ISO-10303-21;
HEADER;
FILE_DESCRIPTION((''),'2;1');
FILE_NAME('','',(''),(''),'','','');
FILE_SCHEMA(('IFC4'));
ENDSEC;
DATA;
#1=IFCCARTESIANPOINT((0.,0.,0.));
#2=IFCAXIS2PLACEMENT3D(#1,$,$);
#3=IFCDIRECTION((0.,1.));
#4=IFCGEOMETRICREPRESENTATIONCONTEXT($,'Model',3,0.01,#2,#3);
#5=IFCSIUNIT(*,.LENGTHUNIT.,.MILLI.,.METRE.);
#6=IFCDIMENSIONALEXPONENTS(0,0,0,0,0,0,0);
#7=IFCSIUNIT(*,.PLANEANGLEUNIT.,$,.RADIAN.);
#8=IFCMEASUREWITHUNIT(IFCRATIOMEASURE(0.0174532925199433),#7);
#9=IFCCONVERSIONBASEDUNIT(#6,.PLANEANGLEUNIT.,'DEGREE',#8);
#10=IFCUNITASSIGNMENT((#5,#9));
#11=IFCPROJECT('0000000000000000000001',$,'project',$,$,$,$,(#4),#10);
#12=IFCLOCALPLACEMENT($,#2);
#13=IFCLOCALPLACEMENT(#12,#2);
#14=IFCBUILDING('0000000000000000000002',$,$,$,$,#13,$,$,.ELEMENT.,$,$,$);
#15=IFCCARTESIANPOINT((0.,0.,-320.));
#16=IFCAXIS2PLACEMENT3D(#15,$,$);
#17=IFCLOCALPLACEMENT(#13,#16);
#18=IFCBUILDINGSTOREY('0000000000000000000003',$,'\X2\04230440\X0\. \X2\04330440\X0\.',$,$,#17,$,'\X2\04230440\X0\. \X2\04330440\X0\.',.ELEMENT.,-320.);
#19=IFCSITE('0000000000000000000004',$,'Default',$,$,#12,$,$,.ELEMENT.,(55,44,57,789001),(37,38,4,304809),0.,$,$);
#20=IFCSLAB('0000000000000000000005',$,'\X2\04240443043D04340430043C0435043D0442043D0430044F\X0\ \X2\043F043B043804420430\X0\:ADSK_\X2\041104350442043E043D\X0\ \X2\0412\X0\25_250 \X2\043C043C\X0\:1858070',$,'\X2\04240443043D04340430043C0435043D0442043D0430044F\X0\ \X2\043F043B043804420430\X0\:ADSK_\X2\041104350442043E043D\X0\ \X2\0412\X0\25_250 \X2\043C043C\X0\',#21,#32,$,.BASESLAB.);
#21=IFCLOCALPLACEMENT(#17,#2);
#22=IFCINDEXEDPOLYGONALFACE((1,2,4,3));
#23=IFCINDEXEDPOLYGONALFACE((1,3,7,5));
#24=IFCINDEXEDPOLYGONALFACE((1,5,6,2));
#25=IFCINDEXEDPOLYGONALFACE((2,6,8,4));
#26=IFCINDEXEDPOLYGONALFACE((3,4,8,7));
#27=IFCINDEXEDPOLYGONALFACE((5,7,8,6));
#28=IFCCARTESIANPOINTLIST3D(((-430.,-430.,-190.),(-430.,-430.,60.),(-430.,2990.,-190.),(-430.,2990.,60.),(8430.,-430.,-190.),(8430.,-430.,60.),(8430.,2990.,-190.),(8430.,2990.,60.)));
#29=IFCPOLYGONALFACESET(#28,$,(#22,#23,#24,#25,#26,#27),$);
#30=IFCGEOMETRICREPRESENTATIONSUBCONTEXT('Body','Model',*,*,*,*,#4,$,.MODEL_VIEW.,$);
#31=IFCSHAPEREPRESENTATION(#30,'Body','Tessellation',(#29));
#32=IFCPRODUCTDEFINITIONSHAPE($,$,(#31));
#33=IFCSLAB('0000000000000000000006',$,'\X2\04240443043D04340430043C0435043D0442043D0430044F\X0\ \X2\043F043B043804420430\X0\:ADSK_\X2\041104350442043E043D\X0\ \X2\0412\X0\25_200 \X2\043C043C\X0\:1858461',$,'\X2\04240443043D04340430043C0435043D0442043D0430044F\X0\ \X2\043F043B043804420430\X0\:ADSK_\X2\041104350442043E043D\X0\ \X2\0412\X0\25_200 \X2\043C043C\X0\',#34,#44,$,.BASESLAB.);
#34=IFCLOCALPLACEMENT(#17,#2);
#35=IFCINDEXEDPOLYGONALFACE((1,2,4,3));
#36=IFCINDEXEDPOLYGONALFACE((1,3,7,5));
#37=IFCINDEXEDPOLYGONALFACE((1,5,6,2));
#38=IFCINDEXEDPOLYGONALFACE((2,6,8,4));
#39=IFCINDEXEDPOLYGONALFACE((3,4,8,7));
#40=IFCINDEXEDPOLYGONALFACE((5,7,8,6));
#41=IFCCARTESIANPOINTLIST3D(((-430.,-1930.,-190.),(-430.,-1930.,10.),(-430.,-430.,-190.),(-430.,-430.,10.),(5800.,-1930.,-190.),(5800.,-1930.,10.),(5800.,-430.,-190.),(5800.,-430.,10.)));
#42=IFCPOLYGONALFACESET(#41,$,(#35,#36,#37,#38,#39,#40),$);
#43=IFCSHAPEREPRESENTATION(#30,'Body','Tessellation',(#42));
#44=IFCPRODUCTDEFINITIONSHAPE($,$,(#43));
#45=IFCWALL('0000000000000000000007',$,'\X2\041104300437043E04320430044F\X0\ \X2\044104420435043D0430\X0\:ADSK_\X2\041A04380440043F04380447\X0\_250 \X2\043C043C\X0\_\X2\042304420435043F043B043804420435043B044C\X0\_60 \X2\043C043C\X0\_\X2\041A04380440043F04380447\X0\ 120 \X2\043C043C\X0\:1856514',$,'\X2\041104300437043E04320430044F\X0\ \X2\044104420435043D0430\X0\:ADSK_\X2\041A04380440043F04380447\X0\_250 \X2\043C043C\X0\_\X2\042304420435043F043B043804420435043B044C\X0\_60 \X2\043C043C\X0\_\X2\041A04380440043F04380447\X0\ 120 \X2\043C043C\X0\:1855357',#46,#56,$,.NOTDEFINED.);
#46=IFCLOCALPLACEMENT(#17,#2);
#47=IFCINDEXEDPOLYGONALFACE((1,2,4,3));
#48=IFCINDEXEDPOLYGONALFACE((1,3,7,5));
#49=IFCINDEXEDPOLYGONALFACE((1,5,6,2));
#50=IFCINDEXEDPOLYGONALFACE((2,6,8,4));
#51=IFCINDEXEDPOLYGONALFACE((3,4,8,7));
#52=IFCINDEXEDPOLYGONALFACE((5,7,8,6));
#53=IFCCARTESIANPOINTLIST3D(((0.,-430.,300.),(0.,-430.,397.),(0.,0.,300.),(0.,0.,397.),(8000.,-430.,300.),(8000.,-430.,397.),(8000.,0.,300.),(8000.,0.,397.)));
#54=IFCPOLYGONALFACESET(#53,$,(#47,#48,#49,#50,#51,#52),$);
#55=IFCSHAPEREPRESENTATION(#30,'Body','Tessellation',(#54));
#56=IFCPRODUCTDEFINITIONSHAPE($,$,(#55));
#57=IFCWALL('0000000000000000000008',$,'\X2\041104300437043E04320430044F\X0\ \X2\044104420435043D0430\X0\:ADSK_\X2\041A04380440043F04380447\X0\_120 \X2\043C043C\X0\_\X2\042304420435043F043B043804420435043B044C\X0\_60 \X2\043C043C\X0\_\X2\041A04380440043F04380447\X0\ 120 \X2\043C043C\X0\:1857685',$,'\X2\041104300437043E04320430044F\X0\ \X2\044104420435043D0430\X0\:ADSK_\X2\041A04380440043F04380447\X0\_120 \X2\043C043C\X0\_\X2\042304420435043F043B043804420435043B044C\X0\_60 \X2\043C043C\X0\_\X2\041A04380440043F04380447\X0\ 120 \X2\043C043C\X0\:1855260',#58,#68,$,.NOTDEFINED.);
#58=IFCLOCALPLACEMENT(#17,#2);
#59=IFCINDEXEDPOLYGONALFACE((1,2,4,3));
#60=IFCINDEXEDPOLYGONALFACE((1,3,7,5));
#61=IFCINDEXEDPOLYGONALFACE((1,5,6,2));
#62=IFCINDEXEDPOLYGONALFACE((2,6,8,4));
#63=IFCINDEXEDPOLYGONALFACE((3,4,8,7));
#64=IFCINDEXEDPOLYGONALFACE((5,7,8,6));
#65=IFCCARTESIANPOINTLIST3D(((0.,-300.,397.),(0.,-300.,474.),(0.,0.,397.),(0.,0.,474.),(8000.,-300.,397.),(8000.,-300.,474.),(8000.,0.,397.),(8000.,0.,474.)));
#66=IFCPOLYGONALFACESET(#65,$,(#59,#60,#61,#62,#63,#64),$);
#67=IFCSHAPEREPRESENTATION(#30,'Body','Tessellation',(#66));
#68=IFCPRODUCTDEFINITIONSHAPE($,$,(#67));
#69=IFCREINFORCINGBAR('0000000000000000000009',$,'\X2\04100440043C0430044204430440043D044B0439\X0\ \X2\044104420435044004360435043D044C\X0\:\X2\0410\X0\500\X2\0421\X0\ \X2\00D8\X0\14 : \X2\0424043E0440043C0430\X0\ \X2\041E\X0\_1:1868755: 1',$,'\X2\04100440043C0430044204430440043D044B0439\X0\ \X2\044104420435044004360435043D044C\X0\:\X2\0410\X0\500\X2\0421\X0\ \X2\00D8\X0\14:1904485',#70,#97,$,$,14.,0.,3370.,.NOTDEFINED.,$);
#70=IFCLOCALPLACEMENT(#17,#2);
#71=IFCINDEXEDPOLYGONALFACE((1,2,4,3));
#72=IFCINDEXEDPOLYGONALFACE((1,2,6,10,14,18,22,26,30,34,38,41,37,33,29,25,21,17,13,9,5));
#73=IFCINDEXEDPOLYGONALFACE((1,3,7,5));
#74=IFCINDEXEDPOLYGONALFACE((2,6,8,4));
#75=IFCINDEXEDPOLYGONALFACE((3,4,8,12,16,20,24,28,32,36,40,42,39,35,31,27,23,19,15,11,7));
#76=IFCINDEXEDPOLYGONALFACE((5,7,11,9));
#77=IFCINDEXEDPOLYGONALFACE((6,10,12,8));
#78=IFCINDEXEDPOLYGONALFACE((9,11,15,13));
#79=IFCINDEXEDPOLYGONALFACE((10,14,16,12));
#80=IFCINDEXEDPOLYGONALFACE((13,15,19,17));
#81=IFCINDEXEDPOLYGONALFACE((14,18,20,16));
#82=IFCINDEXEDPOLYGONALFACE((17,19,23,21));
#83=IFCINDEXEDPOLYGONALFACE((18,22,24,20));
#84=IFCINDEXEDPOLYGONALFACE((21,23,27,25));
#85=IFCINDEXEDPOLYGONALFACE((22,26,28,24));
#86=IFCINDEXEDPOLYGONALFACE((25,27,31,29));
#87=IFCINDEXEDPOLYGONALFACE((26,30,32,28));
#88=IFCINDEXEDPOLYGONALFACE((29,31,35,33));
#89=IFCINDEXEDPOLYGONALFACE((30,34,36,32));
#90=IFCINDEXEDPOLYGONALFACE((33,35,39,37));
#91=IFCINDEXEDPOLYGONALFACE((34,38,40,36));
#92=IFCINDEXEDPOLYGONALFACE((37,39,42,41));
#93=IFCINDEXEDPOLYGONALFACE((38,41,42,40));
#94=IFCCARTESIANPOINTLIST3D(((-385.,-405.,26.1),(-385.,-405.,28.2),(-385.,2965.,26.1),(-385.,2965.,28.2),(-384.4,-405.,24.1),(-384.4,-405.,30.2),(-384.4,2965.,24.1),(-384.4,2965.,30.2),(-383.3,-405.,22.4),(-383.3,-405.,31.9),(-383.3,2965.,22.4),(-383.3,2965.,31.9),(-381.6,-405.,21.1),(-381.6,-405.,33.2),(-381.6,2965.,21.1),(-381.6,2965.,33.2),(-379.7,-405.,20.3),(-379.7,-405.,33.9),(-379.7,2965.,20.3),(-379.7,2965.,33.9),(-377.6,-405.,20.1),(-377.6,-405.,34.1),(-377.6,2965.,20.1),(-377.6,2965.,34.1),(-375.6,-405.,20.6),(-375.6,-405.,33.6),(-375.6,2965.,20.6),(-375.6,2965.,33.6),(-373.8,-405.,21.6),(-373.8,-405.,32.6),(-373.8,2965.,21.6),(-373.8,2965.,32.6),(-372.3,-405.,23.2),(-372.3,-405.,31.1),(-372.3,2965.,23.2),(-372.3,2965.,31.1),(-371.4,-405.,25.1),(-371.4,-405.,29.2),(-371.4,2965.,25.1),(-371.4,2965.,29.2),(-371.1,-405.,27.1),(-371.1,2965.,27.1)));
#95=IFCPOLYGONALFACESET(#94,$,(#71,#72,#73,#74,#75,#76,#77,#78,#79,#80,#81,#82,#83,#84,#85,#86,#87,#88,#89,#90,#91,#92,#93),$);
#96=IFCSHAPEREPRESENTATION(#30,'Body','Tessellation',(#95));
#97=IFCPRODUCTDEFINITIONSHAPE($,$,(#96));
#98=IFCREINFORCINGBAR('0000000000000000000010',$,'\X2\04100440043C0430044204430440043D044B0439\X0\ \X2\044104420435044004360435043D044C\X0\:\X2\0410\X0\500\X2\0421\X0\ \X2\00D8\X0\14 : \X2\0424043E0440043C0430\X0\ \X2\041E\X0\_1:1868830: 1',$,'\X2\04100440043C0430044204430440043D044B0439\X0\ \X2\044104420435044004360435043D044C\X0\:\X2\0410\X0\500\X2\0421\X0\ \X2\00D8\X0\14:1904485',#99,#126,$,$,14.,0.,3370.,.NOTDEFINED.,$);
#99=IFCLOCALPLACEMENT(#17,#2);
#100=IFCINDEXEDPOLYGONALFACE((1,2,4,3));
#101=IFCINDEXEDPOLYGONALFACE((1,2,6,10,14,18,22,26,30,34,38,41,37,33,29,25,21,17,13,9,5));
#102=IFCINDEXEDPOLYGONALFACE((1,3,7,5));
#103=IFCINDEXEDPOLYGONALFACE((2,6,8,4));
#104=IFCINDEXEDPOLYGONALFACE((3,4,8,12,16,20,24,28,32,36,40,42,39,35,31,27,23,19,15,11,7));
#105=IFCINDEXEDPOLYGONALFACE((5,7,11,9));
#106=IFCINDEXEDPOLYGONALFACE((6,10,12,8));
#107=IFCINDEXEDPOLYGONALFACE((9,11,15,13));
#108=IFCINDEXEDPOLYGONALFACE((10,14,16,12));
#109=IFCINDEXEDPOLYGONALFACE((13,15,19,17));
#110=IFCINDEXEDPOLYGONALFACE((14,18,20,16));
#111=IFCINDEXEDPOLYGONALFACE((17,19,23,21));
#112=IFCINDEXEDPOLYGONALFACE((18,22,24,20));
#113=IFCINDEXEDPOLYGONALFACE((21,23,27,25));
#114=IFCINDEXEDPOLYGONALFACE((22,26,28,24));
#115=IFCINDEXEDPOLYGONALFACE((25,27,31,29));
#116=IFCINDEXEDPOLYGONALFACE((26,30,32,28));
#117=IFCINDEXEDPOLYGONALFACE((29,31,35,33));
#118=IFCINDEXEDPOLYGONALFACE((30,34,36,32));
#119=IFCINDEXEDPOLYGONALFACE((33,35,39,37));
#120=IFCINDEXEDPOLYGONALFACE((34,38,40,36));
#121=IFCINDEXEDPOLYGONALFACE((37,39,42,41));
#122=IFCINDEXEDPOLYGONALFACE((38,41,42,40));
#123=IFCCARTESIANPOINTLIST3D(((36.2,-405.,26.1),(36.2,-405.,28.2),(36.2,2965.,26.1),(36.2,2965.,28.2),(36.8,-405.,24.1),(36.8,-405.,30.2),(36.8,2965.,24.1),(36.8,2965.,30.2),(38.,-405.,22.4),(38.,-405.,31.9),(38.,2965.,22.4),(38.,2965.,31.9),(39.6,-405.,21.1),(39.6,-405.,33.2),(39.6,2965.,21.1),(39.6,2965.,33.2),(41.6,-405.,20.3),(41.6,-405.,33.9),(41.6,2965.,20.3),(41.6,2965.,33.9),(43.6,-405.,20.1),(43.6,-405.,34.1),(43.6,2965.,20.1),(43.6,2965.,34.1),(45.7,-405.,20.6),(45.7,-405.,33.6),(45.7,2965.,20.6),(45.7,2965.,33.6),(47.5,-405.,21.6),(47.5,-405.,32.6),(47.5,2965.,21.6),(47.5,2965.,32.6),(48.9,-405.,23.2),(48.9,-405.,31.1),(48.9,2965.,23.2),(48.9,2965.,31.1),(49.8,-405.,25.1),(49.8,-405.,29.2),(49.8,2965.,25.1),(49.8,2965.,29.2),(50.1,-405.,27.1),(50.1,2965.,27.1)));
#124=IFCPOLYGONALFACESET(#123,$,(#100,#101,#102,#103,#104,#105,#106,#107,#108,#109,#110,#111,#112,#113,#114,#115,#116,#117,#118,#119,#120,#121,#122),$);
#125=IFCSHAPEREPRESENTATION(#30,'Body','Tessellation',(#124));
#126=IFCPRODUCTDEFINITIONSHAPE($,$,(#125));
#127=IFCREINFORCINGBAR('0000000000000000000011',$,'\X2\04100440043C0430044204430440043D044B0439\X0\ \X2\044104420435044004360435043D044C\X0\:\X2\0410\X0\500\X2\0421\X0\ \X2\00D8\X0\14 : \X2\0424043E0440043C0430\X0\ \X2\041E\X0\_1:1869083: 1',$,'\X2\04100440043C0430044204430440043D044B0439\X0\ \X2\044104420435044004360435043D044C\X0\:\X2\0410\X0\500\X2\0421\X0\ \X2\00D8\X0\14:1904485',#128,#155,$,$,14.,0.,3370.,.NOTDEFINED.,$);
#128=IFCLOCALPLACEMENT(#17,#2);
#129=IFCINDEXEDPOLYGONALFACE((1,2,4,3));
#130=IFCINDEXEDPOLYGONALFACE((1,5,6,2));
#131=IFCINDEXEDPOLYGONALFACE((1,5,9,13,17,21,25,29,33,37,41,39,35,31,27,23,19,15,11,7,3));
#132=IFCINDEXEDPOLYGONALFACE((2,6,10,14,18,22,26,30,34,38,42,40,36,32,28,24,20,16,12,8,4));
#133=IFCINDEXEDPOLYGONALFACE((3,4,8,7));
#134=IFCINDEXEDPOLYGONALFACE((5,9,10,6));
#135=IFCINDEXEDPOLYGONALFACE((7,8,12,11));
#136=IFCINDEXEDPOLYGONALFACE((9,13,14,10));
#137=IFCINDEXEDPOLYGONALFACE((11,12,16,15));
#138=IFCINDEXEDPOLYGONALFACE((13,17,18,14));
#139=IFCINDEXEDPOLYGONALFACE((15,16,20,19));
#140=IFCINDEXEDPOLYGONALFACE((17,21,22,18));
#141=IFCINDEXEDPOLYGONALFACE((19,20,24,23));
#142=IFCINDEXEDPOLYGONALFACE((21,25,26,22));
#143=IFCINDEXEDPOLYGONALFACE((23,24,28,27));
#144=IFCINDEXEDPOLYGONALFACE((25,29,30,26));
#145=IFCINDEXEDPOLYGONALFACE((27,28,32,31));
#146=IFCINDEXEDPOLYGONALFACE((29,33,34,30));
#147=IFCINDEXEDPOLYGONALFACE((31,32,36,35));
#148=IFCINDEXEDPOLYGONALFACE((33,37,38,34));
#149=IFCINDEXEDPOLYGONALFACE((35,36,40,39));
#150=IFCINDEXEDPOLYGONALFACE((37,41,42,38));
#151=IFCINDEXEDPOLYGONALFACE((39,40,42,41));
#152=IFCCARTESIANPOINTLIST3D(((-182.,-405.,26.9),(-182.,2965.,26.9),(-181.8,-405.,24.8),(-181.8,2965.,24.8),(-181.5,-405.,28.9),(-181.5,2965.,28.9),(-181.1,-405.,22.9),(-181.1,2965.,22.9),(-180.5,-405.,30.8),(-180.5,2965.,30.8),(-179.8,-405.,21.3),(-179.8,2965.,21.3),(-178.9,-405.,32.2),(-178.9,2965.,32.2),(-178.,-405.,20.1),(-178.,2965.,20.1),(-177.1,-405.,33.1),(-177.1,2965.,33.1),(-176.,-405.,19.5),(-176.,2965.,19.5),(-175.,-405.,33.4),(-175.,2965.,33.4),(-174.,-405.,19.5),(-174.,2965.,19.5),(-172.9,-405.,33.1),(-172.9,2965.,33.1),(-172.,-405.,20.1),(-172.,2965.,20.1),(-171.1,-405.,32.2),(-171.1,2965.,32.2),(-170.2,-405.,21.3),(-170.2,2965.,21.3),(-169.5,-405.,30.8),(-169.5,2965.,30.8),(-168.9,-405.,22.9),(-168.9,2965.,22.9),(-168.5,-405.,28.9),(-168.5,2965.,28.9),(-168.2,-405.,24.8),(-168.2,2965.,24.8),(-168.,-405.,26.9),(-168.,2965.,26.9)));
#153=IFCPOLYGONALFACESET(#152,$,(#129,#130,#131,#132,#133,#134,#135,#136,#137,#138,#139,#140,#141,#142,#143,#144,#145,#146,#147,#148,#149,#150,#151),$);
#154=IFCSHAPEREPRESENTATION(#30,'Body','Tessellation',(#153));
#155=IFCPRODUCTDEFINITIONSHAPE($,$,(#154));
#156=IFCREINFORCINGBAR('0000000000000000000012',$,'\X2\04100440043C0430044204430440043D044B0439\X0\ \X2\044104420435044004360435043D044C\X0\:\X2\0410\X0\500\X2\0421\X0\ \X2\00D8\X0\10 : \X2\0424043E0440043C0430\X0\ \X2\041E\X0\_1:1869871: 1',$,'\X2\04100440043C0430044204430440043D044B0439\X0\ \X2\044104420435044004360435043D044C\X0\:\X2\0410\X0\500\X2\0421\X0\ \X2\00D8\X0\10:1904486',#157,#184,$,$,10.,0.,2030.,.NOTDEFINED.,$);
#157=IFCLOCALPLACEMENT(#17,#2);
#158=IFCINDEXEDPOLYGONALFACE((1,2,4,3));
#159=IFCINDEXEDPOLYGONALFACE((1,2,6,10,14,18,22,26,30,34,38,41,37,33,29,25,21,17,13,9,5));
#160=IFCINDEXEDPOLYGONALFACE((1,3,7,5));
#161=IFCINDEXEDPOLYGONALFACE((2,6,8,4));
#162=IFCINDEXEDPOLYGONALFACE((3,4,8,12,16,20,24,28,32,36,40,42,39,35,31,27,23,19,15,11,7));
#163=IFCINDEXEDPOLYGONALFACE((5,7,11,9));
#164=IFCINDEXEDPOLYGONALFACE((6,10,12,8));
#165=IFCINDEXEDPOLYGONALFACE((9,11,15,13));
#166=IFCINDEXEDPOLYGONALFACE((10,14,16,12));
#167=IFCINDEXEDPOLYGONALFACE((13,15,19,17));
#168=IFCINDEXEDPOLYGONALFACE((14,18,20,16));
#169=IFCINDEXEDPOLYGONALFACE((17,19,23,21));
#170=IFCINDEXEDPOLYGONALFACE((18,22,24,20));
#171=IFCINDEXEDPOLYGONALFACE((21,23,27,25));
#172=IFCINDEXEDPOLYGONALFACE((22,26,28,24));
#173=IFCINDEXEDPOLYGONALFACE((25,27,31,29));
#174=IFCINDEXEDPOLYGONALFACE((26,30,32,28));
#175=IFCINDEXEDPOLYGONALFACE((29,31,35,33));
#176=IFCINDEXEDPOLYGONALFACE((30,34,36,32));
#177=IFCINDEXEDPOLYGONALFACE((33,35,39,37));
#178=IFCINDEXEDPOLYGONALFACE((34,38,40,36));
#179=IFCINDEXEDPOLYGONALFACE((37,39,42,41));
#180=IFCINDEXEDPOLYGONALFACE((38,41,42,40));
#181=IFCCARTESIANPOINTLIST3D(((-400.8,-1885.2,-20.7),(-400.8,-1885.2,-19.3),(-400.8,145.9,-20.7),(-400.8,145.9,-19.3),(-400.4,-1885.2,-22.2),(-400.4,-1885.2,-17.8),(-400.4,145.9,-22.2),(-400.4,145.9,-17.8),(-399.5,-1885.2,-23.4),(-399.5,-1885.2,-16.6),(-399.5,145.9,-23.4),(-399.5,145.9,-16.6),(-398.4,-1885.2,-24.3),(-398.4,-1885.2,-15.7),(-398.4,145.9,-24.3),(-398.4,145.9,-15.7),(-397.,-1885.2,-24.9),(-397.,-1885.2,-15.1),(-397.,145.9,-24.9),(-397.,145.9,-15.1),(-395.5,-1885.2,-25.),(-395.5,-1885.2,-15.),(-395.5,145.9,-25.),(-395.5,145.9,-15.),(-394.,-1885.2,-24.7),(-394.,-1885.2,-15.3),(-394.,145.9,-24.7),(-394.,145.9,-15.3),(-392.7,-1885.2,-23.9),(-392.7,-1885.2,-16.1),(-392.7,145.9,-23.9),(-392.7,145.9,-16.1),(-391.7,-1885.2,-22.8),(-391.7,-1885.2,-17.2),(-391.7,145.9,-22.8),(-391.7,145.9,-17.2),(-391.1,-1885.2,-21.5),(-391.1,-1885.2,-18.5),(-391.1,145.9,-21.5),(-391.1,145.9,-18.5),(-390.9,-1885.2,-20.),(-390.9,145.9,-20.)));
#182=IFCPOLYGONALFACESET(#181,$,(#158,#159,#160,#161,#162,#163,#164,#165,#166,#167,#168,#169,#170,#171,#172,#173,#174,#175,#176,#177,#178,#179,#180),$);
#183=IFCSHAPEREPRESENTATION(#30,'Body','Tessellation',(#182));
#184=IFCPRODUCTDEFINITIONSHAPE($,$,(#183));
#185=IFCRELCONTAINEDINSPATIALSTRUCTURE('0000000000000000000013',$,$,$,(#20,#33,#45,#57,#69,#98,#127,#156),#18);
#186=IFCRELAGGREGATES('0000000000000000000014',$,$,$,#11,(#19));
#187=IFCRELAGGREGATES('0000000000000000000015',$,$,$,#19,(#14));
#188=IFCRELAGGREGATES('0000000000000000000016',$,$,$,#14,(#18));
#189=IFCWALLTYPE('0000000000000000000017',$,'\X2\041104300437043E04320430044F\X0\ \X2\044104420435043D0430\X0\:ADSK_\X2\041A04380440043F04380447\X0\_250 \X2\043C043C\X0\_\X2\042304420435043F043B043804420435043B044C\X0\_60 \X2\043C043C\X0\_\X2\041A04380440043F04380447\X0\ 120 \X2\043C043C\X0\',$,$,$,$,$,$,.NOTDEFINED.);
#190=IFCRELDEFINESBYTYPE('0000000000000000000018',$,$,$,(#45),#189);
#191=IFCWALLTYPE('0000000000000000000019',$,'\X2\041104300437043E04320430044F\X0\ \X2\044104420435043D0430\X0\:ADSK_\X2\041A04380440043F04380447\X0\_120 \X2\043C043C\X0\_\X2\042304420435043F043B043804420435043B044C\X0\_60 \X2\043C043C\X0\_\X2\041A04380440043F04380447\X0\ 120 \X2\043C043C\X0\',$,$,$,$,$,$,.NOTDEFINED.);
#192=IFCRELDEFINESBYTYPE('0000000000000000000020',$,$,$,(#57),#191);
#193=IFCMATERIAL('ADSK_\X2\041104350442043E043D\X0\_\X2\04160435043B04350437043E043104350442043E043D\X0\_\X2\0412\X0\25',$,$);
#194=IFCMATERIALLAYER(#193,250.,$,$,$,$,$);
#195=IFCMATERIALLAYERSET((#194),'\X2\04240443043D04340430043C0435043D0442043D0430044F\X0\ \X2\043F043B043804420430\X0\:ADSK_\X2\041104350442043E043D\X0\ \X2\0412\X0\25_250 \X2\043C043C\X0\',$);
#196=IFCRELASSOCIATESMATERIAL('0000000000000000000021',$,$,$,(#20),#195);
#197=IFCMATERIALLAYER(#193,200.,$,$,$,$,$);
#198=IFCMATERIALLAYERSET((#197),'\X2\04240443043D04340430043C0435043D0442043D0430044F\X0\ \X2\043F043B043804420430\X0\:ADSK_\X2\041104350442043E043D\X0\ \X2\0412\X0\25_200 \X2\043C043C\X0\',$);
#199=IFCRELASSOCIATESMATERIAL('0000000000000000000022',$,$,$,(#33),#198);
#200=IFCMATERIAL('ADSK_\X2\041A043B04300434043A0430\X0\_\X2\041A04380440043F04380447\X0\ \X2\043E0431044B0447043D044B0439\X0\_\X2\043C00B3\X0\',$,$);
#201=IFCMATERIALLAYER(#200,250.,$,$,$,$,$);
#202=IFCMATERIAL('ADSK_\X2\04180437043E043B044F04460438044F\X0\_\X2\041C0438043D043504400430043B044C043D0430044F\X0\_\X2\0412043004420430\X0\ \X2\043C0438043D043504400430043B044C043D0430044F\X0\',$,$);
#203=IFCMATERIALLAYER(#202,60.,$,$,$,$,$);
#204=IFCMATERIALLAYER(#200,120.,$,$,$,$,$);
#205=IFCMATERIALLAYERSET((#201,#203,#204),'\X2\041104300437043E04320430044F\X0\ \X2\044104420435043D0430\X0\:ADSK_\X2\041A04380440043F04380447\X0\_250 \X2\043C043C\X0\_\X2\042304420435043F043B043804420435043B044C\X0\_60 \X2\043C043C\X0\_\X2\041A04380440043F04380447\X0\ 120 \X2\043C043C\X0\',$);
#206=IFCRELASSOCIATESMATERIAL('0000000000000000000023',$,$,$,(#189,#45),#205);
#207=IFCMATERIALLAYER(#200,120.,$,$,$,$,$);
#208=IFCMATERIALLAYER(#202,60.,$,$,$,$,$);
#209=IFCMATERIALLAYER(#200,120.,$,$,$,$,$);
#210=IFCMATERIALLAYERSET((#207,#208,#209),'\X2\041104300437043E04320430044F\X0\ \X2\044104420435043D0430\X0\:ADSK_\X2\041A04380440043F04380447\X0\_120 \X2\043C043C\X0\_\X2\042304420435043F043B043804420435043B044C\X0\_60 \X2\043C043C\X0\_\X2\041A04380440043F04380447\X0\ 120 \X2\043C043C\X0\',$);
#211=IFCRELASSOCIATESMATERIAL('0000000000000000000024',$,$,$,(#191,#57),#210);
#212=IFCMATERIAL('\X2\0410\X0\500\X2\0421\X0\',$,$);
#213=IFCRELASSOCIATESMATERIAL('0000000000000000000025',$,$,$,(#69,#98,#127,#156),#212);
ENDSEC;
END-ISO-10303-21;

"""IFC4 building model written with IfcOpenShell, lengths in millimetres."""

from ifc_helpers import new_model, entity, si_unit, converted_unit, direction, frame, frame_2d, origin, place, context, subcontext, project, spatial, polyline, rectangle, extrude, clip, bounded_halfspace, material, layer, layer_set, layer_usage, type_object, element, save


model = new_model("IFC4")

# Units and contexts
model_context = context("Model", 3, precision=0.01, world=origin(), true_north=direction((0.0, 1.0)))
body_context = subcontext(model_context, "Body", "Model", "MODEL_VIEW")
ifc_project = project(units=[si_unit("LENGTHUNIT", "METRE", prefix="MILLI"), converted_unit("PLANEANGLEUNIT", "DEGREE", entity("IfcRatioMeasure", 0.0174532925199433), si_unit("PLANEANGLEUNIT", "RADIAN"), dimensions=[0, 0, 0, 0, 0, 0, 0])], contexts=[model_context])

# Site, building, storey
site_placement = place(None, origin())
site = spatial("IfcSite", under=ifc_project, at=site_placement, Name="Default", CompositionType="ELEMENT", RefLatitude=(55, 44, 57, 789001), RefLongitude=(37, 38, 4, 304809), RefElevation=0.0)
building_placement = place(site_placement, origin())
building = spatial("IfcBuilding", under=site, at=building_placement, CompositionType="ELEMENT")
storey_placement = place(building_placement, frame((0.0, 0.0, -320.0)))
storey = spatial("IfcBuildingStorey", under=building, at=storey_placement, Name="Ур. гр.", LongName="Ур. гр.", CompositionType="ELEMENT", Elevation=-320.0)

# Slabs
ifc_material_1 = material(Name="ADSK_Бетон_Железобетон_В25")
ifc_layer_1 = layer(ifc_material_1, 250.0)
ifc_layer_set_1 = layer_set([ifc_layer_1], Name="Фундаментная плита:ADSK_Бетон В25_250 мм")
ifc_layer_usage_1 = layer_usage(ifc_layer_set_1, "AXIS3", "POSITIVE", 0.0)
slab_1_placement = place(storey_placement, origin())
element("IfcSlab", 1, at=slab_1_placement, inside=storey, material=ifc_layer_usage_1, Name="Фундаментная плита:ADSK_Бетон В25_250 мм:1858070", ObjectType="Фундаментная плита:ADSK_Бетон В25_250 мм", PredefinedType="BASESLAB", context=body_context, shape_type="SweptSolid", body=[
    extrude(rectangle(XDim=3420.0, YDim=8860.0, at=frame_2d((0.0, 0.0), x_axis=(1.0, 0.0))), frame((4000.0, 1280.0, 60.0), z_axis=(0.0, 0.0, -1.0), x_axis=(0.0, 1.0, 0.0)), (0.0, 0.0, 1.0), 250.0),
])
ifc_layer_2 = layer(ifc_material_1, 200.0)
ifc_layer_set_2 = layer_set([ifc_layer_2], Name="Фундаментная плита:ADSK_Бетон В25_200 мм")
ifc_layer_usage_2 = layer_usage(ifc_layer_set_2, "AXIS3", "POSITIVE", 0.0)
slab_2_placement = place(storey_placement, origin())
element("IfcSlab", 2, at=slab_2_placement, inside=storey, material=ifc_layer_usage_2, Name="Фундаментная плита:ADSK_Бетон В25_200 мм:1858461", ObjectType="Фундаментная плита:ADSK_Бетон В25_200 мм", PredefinedType="BASESLAB", context=body_context, shape_type="SweptSolid", body=[
    extrude(rectangle(XDim=1500.0, YDim=6230.0, at=frame_2d((0.0, 0.0), x_axis=(1.0, 0.0))), frame((2685.0, -1180.0, 10.0), z_axis=(0.0, 0.0, -1.0), x_axis=(0.0, 1.0, 0.0)), (0.0, 0.0, 1.0), 200.0),
])

# Walls
ifc_material_2 = material(Name="ADSK_Кладка_Кирпич обычный_м³")
ifc_layer_3 = layer(ifc_material_2, 250.0)
ifc_material_3 = material(Name="ADSK_Изоляция_Минеральная_Вата минеральная")
ifc_layer_4 = layer(ifc_material_3, 60.0)
ifc_layer_5 = layer(ifc_material_2, 120.0)
ifc_layer_set_3 = layer_set([ifc_layer_3, ifc_layer_4, ifc_layer_5], Name="Базовая стена:ADSK_Кирпич_250 мм_Утеплитель_60 мм_Кирпич 120 мм")
ifc_layer_usage_3 = layer_usage(ifc_layer_set_3, "AXIS2", "POSITIVE", -215.0)
wall_type_1 = type_object("IfcWallType", Name="Базовая стена:ADSK_Кирпич_250 мм_Утеплитель_60 мм_Кирпич 120 мм", PredefinedType="NOTDEFINED", material=ifc_layer_set_3)
wall_1_placement = place(storey_placement, frame((0.0, -215.0, 300.0)))
element("IfcWall", 3, at=wall_1_placement, inside=storey, type_object=wall_type_1, material=ifc_layer_usage_3, Name="Базовая стена:ADSK_Кирпич_250 мм_Утеплитель_60 мм_Кирпич 120 мм:1856514", ObjectType="Базовая стена:ADSK_Кирпич_250 мм_Утеплитель_60 мм_Кирпич 120 мм:1855357", PredefinedType="NOTDEFINED", context=body_context, shape_type="Clipping", body=[
    clip(extrude(rectangle(XDim=8000.0, YDim=430.0, at=frame_2d((4000.0, 0.0), x_axis=(-1.0, 0.0))), origin(), (0.0, 0.0, 1.0), 97.0), bounded_halfspace(frame((0.0, -215.0, 97.0), z_axis=(0.0, 0.0, -1.0), x_axis=(0.0, 1.0, 0.0)), True, frame((0.0, -215.0, 97.0)), polyline([(0.0, 0.0), (8000.0, 0.0), (8000.0, 130.0), (8000.0, 430.0), (0.0, 430.0), (0.0, 130.0), (0.0, 0.0)]))),
])
ifc_layer_6 = layer(ifc_material_2, 120.0)
ifc_layer_7 = layer(ifc_material_3, 60.0)
ifc_layer_8 = layer(ifc_material_2, 120.0)
ifc_layer_set_4 = layer_set([ifc_layer_6, ifc_layer_7, ifc_layer_8], Name="Базовая стена:ADSK_Кирпич_120 мм_Утеплитель_60 мм_Кирпич 120 мм")
ifc_layer_usage_4 = layer_usage(ifc_layer_set_4, "AXIS2", "POSITIVE", -150.0)
wall_type_2 = type_object("IfcWallType", Name="Базовая стена:ADSK_Кирпич_120 мм_Утеплитель_60 мм_Кирпич 120 мм", PredefinedType="NOTDEFINED", material=ifc_layer_set_4)
wall_2_placement = place(storey_placement, frame((0.0, -150.0, 397.0)))
element("IfcWall", 4, at=wall_2_placement, inside=storey, type_object=wall_type_2, material=ifc_layer_usage_4, Name="Базовая стена:ADSK_Кирпич_120 мм_Утеплитель_60 мм_Кирпич 120 мм:1857685", ObjectType="Базовая стена:ADSK_Кирпич_120 мм_Утеплитель_60 мм_Кирпич 120 мм:1855260", PredefinedType="NOTDEFINED", context=body_context, shape_type="SweptSolid", body=[
    extrude(rectangle(XDim=8000.0, YDim=300.0, at=frame_2d((4000.0, 0.0), x_axis=(-1.0, 0.0))), origin(), (0.0, 0.0, 1.0), 77.0),
])

# Reinforcing bars
ifc_material_4 = material(Name="А500С")
reinforcing_bar_1_placement = place(storey_placement, origin())
element("IfcReinforcingBar", 5, at=reinforcing_bar_1_placement, inside=storey, material=ifc_material_4, Name="Арматурный стержень:А500С Ø14 : Форма О_1:1868755: 1", ObjectType="Арматурный стержень:А500С Ø14:1904485", BarLength=3370.0, CrossSectionArea=0.0, NominalDiameter=14.0, PredefinedType="NOTDEFINED", context=body_context, shape_type="AdvancedSweptSolid", body=[
    entity("IfcSweptDiskSolid", entity("IfcCompositeCurve", [entity("IfcCompositeCurveSegment", "CONTINUOUS", True, entity("IfcPolyline", [entity("IfcCartesianPoint", [-378.1, -405.0, 27.1]), entity("IfcCartesianPoint", [-378.1, 2965.0, 27.1])]))], False), 7.0, None, 0.0, 1.0),
])
reinforcing_bar_2_placement = place(storey_placement, origin())
element("IfcReinforcingBar", 6, at=reinforcing_bar_2_placement, inside=storey, material=ifc_material_4, Name="Арматурный стержень:А500С Ø14 : Форма О_1:1868830: 1", ObjectType="Арматурный стержень:А500С Ø14:1904485", BarLength=3370.0, CrossSectionArea=0.0, NominalDiameter=14.0, PredefinedType="NOTDEFINED", context=body_context, shape_type="AdvancedSweptSolid", body=[
    entity("IfcSweptDiskSolid", entity("IfcCompositeCurve", [entity("IfcCompositeCurveSegment", "CONTINUOUS", True, entity("IfcPolyline", [entity("IfcCartesianPoint", [43.1, -405.0, 27.1]), entity("IfcCartesianPoint", [43.1, 2965.0, 27.1])]))], False), 7.0, None, 0.0, 1.0),
])
reinforcing_bar_3_placement = place(storey_placement, origin())
element("IfcReinforcingBar", 7, at=reinforcing_bar_3_placement, inside=storey, material=ifc_material_4, Name="Арматурный стержень:А500С Ø14 : Форма О_1:1869083: 1", ObjectType="Арматурный стержень:А500С Ø14:1904485", BarLength=3370.0, CrossSectionArea=0.0, NominalDiameter=14.0, PredefinedType="NOTDEFINED", context=body_context, shape_type="AdvancedSweptSolid", body=[
    entity("IfcSweptDiskSolid", entity("IfcCompositeCurve", [entity("IfcCompositeCurveSegment", "CONTINUOUS", True, entity("IfcPolyline", [entity("IfcCartesianPoint", [-175.0, -405.0, 26.4]), entity("IfcCartesianPoint", [-175.0, 2965.0, 26.4])]))], False), 7.0, None, 0.0, 1.0),
])
reinforcing_bar_4_placement = place(storey_placement, origin())
element("IfcReinforcingBar", 8, at=reinforcing_bar_4_placement, inside=storey, material=ifc_material_4, Name="Арматурный стержень:А500С Ø10 : Форма О_1:1869871: 1", ObjectType="Арматурный стержень:А500С Ø10:1904486", BarLength=2030.0, CrossSectionArea=0.0, NominalDiameter=10.0, PredefinedType="NOTDEFINED", context=body_context, shape_type="AdvancedSweptSolid", body=[
    entity("IfcSweptDiskSolid", entity("IfcCompositeCurve", [entity("IfcCompositeCurveSegment", "CONTINUOUS", True, entity("IfcPolyline", [entity("IfcCartesianPoint", [-395.9, -1885.2, -20.0]), entity("IfcCartesianPoint", [-395.9, 145.9, -20.0])]))], False), 5.0, None, 0.0, 1.0),
])

save(model, "model.ifc")
